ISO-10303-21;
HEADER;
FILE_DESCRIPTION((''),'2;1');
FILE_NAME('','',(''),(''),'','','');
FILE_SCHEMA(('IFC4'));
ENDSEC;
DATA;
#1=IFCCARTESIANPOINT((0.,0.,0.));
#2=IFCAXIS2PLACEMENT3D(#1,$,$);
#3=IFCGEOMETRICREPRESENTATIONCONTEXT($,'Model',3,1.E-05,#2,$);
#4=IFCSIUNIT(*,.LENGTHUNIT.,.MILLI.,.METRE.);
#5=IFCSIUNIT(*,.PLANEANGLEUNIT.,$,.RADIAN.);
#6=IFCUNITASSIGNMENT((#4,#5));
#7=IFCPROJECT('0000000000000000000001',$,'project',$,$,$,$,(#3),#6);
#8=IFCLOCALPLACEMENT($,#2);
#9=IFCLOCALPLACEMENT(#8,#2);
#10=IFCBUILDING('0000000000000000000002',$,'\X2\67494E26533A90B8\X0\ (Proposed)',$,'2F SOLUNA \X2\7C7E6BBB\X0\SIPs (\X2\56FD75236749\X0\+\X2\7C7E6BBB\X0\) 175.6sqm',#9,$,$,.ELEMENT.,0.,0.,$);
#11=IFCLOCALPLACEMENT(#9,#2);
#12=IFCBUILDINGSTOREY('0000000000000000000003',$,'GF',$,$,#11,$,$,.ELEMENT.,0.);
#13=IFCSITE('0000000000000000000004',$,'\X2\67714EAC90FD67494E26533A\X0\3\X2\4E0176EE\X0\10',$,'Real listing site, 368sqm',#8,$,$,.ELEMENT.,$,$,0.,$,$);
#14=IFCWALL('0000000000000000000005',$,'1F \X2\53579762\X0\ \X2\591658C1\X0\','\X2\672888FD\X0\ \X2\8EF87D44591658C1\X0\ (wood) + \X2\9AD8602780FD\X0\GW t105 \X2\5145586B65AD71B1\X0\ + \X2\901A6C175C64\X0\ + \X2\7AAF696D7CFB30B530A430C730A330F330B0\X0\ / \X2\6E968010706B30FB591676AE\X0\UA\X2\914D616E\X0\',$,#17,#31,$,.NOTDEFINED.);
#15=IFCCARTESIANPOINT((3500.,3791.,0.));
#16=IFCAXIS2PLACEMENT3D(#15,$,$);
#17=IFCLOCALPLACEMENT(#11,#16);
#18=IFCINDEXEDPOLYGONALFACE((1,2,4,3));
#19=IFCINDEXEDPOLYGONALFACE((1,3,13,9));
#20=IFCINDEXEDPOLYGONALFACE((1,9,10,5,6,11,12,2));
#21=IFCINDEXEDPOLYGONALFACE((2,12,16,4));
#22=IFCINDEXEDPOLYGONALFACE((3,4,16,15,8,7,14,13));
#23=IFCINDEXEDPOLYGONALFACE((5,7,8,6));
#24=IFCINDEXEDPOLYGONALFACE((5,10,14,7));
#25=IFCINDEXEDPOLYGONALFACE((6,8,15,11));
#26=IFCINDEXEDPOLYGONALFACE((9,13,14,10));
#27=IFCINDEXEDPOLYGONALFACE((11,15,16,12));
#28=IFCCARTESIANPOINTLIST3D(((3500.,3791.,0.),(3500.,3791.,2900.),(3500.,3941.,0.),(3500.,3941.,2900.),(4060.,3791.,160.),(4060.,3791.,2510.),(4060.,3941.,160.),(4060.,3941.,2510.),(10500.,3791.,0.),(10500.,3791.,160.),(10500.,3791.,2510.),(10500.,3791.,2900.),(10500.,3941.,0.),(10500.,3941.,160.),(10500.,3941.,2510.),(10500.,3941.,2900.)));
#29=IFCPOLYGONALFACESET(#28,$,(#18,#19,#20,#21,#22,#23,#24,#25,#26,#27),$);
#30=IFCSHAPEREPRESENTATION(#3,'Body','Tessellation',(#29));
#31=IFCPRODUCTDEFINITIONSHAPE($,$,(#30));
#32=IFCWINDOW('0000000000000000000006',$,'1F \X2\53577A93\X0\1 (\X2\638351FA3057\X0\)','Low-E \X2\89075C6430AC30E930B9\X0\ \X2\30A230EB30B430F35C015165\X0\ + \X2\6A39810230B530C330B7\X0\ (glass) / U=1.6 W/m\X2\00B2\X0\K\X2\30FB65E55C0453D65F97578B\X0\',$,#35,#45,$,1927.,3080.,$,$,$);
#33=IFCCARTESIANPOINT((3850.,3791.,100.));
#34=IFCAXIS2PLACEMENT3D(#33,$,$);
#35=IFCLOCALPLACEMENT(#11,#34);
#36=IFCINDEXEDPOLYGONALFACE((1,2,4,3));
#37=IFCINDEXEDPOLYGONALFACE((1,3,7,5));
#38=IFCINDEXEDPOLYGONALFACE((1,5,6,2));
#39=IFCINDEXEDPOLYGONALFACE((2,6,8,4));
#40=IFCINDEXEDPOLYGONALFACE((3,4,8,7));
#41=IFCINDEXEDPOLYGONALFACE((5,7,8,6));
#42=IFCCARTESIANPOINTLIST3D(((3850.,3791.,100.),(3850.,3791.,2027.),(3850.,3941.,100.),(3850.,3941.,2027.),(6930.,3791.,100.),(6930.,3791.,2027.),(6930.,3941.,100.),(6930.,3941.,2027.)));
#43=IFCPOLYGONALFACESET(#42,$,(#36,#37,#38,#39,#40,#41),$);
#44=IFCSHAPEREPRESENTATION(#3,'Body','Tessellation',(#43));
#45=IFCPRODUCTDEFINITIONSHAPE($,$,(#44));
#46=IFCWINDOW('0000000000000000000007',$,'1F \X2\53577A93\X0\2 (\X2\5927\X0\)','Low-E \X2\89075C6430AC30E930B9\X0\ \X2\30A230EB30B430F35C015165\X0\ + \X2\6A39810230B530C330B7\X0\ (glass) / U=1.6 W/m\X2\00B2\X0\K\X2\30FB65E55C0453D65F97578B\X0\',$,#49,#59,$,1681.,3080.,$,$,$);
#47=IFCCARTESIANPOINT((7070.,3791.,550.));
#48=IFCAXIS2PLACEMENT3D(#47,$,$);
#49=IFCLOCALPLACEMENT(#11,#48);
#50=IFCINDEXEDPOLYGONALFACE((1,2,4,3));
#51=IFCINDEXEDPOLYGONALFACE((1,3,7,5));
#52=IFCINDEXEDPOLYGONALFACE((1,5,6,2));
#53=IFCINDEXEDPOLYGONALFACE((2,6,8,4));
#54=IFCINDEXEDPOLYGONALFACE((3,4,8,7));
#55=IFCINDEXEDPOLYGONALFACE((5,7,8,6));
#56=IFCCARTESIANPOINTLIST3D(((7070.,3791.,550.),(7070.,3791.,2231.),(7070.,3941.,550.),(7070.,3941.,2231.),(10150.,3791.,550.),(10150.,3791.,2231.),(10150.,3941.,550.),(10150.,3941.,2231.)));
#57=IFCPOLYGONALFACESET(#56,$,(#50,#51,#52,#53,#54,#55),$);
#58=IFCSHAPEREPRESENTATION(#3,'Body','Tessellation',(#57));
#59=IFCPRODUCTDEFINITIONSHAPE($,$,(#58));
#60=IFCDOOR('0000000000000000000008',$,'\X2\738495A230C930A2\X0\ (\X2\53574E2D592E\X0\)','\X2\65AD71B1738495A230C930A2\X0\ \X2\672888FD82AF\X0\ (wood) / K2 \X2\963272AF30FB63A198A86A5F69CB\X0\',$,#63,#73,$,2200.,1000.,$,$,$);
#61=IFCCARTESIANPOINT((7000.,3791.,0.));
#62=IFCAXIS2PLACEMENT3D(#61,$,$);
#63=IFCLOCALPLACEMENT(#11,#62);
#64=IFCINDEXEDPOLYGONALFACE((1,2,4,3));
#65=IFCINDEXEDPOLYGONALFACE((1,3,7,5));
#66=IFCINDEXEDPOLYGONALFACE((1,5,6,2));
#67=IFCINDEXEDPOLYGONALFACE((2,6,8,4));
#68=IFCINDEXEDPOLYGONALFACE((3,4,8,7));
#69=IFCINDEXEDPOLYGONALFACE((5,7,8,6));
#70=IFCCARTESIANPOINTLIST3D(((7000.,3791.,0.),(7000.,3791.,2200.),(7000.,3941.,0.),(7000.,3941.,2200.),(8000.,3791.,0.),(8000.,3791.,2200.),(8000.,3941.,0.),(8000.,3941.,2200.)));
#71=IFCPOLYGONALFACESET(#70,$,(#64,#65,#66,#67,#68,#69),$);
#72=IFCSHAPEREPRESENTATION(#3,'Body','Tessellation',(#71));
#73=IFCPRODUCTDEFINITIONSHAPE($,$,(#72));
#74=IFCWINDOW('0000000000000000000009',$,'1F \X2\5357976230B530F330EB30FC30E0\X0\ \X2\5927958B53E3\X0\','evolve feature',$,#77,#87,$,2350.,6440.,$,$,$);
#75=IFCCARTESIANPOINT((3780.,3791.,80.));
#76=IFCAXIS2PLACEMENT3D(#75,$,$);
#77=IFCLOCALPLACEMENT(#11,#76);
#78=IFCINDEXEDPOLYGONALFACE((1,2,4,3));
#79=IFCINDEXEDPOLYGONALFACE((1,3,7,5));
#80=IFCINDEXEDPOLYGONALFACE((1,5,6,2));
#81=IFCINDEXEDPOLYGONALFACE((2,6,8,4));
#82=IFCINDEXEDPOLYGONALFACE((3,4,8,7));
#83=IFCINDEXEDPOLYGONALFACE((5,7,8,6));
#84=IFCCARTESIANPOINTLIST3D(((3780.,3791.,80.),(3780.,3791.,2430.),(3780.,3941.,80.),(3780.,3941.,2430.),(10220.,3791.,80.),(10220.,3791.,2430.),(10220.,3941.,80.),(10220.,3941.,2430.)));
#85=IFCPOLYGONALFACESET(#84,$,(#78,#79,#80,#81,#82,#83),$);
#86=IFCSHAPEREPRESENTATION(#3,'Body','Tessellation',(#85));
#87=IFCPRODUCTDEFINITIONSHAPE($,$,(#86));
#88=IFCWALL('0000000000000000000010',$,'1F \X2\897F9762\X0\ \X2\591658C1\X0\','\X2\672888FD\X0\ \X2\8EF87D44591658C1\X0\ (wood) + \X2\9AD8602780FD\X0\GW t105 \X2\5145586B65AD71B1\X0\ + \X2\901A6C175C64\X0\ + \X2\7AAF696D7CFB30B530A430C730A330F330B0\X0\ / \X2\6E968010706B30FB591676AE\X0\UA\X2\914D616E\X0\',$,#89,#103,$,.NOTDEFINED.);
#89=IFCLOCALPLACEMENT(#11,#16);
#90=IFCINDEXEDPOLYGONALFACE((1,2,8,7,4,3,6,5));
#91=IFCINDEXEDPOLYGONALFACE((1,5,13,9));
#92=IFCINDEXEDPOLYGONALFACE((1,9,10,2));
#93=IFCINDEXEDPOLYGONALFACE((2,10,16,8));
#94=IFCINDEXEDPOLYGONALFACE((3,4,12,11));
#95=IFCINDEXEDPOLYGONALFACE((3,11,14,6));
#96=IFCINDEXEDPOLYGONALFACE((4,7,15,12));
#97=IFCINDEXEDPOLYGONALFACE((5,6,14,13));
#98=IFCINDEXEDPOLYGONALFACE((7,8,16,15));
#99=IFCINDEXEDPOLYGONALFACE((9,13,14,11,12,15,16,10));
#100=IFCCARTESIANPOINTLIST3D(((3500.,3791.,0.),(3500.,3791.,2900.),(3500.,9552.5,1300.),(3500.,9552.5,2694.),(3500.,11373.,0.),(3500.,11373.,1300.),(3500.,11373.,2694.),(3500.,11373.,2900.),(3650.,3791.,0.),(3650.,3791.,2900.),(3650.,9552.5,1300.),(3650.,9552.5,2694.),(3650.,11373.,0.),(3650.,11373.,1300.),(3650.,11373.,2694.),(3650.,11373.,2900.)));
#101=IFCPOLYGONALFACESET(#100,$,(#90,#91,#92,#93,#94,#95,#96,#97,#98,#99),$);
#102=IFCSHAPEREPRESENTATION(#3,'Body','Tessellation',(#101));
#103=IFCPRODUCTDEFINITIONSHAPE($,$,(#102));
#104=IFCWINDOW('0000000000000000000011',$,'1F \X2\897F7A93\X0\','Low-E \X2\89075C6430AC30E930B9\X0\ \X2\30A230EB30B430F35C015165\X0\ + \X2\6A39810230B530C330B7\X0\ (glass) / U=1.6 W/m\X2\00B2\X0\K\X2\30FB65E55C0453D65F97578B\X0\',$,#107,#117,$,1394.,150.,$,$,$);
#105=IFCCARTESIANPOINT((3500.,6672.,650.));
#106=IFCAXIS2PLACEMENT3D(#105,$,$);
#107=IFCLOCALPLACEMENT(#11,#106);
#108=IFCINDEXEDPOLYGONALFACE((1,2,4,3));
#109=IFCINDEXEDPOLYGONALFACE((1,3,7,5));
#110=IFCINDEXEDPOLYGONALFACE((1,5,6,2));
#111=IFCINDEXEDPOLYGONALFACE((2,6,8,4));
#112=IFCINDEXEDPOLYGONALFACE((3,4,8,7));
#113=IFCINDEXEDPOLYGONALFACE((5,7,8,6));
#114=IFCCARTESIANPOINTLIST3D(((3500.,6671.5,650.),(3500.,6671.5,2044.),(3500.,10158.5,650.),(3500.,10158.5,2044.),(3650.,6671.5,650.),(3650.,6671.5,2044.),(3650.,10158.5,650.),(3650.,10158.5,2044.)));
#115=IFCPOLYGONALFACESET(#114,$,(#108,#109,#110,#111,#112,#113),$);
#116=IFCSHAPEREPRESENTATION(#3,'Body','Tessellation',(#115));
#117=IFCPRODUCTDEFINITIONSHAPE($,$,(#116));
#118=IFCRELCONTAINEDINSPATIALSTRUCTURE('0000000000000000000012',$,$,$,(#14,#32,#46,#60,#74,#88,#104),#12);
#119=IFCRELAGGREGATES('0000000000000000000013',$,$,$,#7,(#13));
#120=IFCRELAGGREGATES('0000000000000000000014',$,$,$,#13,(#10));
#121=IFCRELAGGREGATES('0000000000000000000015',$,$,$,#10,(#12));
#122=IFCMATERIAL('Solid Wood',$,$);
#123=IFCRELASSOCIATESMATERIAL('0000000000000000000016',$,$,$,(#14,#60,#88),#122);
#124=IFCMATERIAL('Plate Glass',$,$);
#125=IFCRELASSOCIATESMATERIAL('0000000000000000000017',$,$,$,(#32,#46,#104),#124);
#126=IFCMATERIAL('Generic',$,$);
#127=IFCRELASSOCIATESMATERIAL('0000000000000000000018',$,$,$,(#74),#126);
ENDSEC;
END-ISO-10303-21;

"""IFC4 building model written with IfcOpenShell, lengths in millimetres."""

from ifc_helpers import new_model, si_unit, frame, frame_2d, origin, place, context, project, spatial, rectangle, extrude, material, element, fill, save


model = new_model("IFC4")

# Units and contexts
model_context = context("Model", 3, precision=1e-05, world=origin())
ifc_project = project(units=[si_unit("LENGTHUNIT", "METRE", prefix="MILLI"), si_unit("PLANEANGLEUNIT", "RADIAN")], contexts=[model_context])

# Site, building, storey
site_placement = place(None, origin())
site = spatial("IfcSite", under=ifc_project, at=site_placement, Name="東京都杉並区3丁目10", ObjectType="Real listing site, 368sqm", CompositionType="ELEMENT", RefElevation=0.0)
building_placement = place(site_placement, origin())
building = spatial("IfcBuilding", under=site, at=building_placement, Name="杉並区邸 (Proposed)", ObjectType="2F SOLUNA 籾殻SIPs (国産杉+籾殻) 175.6sqm", CompositionType="ELEMENT", ElevationOfRefHeight=0.0, ElevationOfTerrain=0.0)
storey_placement = place(building_placement, origin())
storey = spatial("IfcBuildingStorey", under=building, at=storey_placement, Name="GF", CompositionType="ELEMENT", Elevation=0.0)

# Shared definitions
ifc_material_1 = material(Name="Solid Wood")
ifc_material_2 = material(Name="Generic")

# Wall, openings, windows, door
wall_1_placement = place(storey_placement, frame((3500.0, 3791.0, 0.0)))
wall_1 = element("IfcWall", 1, at=wall_1_placement, inside=storey, material=ifc_material_1, Name="1F 南面 外壁", Description="木製 軸組外壁 (wood) + 高性能GW t105 充填断熱 + 通気層 + 窯業系サイディング / 準耐火・外皮UA配慮", PredefinedType="NOTDEFINED", context=model_context, shape_type="SweptSolid", body=[
    extrude(rectangle(XDim=7000.0, YDim=150.0, at=frame_2d((3500.0, 75.0))), frame((3500.0, 3791.0, 0.0)), (0.0, 0.0, 1.0), 2900.0),
])
opening_1_placement = place(storey_placement, frame((3850.0, 3791.0, 100.0)))
opening_1 = element("IfcOpeningElement", 2, at=opening_1_placement, cuts=wall_1, PredefinedType="NOTDEFINED", context=model_context, shape_type="SweptSolid", body=[
    extrude(rectangle(XDim=3080.0, YDim=150.0, at=frame_2d((1540.0, 75.0))), frame((3850.0, 3791.0, 100.0)), (0.0, 0.0, 1.0), 1927.0),
])
opening_2_placement = place(storey_placement, frame((7070.0, 3791.0, 550.0)))
opening_2 = element("IfcOpeningElement", 3, at=opening_2_placement, cuts=wall_1, PredefinedType="NOTDEFINED", context=model_context, shape_type="SweptSolid", body=[
    extrude(rectangle(XDim=3080.0, YDim=150.0, at=frame_2d((1540.0, 75.0))), frame((7070.0, 3791.0, 550.0)), (0.0, 0.0, 1.0), 1681.0),
])
opening_3_placement = place(storey_placement, frame((7000.0, 3791.0, 0.0)))
opening_3 = element("IfcOpeningElement", 4, at=opening_3_placement, cuts=wall_1, PredefinedType="NOTDEFINED", context=model_context, shape_type="SweptSolid", body=[
    extrude(rectangle(XDim=1000.0, YDim=150.0, at=frame_2d((500.0, 75.0))), frame((7000.0, 3791.0, 0.0)), (0.0, 0.0, 1.0), 2200.0),
])
opening_4_placement = place(storey_placement, frame((3780.0, 3791.0, 80.0)))
opening_4 = element("IfcOpeningElement", 5, at=opening_4_placement, cuts=wall_1, PredefinedType="NOTDEFINED", context=model_context, shape_type="SweptSolid", body=[
    extrude(rectangle(XDim=6440.0, YDim=150.0, at=frame_2d((3220.0, 75.0))), frame((3780.0, 3791.0, 80.0)), (0.0, 0.0, 1.0), 2350.0),
])
ifc_material_3 = material(Name="Plate Glass")
window_1_placement = place(storey_placement, frame((3850.0, 3791.0, 100.0)))
window_1 = element("IfcWindow", 6, at=window_1_placement, inside=storey, material=ifc_material_3, Name="1F 南窓1 (掃出し)", Description="Low-E 複層ガラス アルゴン封入 + 樹脂サッシ (glass) / U=1.6 W/m²K・日射取得型", OverallHeight=1927.0, OverallWidth=3080.0, context=model_context, shape_type="SweptSolid", body=[
    extrude(rectangle(XDim=3080.0, YDim=150.0, at=frame_2d((1540.0, 75.0))), frame((3850.0, 3791.0, 100.0)), (0.0, 0.0, 1.0), 1927.0),
])
fill(opening_1, window_1)
window_2_placement = place(storey_placement, frame((7070.0, 3791.0, 550.0)))
window_2 = element("IfcWindow", 7, at=window_2_placement, inside=storey, material=ifc_material_3, Name="1F 南窓2 (大)", Description="Low-E 複層ガラス アルゴン封入 + 樹脂サッシ (glass) / U=1.6 W/m²K・日射取得型", OverallHeight=1681.0, OverallWidth=3080.0, context=model_context, shape_type="SweptSolid", body=[
    extrude(rectangle(XDim=3080.0, YDim=150.0, at=frame_2d((1540.0, 75.0))), frame((7070.0, 3791.0, 550.0)), (0.0, 0.0, 1.0), 1681.0),
])
fill(opening_2, window_2)
door_placement = place(storey_placement, frame((7000.0, 3791.0, 0.0)))
door = element("IfcDoor", 8, at=door_placement, inside=storey, material=ifc_material_1, Name="玄関ドア (南中央)", Description="断熱玄関ドア 木製芯 (wood) / K2 防犯・採風機構", OverallHeight=2200.0, OverallWidth=1000.0, context=model_context, shape_type="SweptSolid", body=[
    extrude(rectangle(XDim=1000.0, YDim=150.0, at=frame_2d((500.0, 75.0))), frame((7000.0, 3791.0, 0.0)), (0.0, 0.0, 1.0), 2200.0),
])
fill(opening_3, door)
window_3_placement = place(storey_placement, frame((3780.0, 3791.0, 80.0)))
window_3 = element("IfcWindow", 9, at=window_3_placement, inside=storey, material=ifc_material_2, Name="1F 南面サンルーム 大開口", Description="evolve feature", OverallHeight=2350.0, OverallWidth=6440.0, context=model_context, shape_type="SweptSolid", body=[
    extrude(rectangle(XDim=6440.0, YDim=150.0, at=frame_2d((3220.0, 75.0))), frame((3780.0, 3791.0, 80.0)), (0.0, 0.0, 1.0), 2350.0),
])
fill(opening_4, window_3)

# Wall, opening, window
wall_2_placement = place(storey_placement, frame((3500.0, 3791.0, 0.0)))
wall_2 = element("IfcWall", 10, at=wall_2_placement, inside=storey, material=ifc_material_1, Name="1F 西面 外壁", Description="木製 軸組外壁 (wood) + 高性能GW t105 充填断熱 + 通気層 + 窯業系サイディング / 準耐火・外皮UA配慮", PredefinedType="NOTDEFINED", context=model_context, shape_type="SweptSolid", body=[
    extrude(rectangle(XDim=150.0, YDim=7582.0, at=frame_2d((75.0, 3791.0))), frame((3500.0, 3791.0, 0.0)), (0.0, 0.0, 1.0), 2900.0),
])
opening_5_placement = place(storey_placement, frame((3500.0, 6672.0, 650.0)))
opening_5 = element("IfcOpeningElement", 11, at=opening_5_placement, cuts=wall_2, PredefinedType="NOTDEFINED", context=model_context, shape_type="SweptSolid", body=[
    extrude(rectangle(XDim=150.0, YDim=3487.0, at=frame_2d((75.0, 1743.0))), frame((3500.0, 6672.0, 650.0)), (0.0, 0.0, 1.0), 1394.0),
])
window_4_placement = place(storey_placement, frame((3500.0, 6672.0, 650.0)))
window_4 = element("IfcWindow", 12, at=window_4_placement, inside=storey, material=ifc_material_3, Name="1F 西窓", Description="Low-E 複層ガラス アルゴン封入 + 樹脂サッシ (glass) / U=1.6 W/m²K・日射取得型", OverallHeight=1394.0, OverallWidth=150.0, context=model_context, shape_type="SweptSolid", body=[
    extrude(rectangle(XDim=150.0, YDim=3487.0, at=frame_2d((75.0, 1743.0))), frame((3500.0, 6672.0, 650.0)), (0.0, 0.0, 1.0), 1394.0),
])
fill(opening_5, window_4)

save(model, "model.ifc")
